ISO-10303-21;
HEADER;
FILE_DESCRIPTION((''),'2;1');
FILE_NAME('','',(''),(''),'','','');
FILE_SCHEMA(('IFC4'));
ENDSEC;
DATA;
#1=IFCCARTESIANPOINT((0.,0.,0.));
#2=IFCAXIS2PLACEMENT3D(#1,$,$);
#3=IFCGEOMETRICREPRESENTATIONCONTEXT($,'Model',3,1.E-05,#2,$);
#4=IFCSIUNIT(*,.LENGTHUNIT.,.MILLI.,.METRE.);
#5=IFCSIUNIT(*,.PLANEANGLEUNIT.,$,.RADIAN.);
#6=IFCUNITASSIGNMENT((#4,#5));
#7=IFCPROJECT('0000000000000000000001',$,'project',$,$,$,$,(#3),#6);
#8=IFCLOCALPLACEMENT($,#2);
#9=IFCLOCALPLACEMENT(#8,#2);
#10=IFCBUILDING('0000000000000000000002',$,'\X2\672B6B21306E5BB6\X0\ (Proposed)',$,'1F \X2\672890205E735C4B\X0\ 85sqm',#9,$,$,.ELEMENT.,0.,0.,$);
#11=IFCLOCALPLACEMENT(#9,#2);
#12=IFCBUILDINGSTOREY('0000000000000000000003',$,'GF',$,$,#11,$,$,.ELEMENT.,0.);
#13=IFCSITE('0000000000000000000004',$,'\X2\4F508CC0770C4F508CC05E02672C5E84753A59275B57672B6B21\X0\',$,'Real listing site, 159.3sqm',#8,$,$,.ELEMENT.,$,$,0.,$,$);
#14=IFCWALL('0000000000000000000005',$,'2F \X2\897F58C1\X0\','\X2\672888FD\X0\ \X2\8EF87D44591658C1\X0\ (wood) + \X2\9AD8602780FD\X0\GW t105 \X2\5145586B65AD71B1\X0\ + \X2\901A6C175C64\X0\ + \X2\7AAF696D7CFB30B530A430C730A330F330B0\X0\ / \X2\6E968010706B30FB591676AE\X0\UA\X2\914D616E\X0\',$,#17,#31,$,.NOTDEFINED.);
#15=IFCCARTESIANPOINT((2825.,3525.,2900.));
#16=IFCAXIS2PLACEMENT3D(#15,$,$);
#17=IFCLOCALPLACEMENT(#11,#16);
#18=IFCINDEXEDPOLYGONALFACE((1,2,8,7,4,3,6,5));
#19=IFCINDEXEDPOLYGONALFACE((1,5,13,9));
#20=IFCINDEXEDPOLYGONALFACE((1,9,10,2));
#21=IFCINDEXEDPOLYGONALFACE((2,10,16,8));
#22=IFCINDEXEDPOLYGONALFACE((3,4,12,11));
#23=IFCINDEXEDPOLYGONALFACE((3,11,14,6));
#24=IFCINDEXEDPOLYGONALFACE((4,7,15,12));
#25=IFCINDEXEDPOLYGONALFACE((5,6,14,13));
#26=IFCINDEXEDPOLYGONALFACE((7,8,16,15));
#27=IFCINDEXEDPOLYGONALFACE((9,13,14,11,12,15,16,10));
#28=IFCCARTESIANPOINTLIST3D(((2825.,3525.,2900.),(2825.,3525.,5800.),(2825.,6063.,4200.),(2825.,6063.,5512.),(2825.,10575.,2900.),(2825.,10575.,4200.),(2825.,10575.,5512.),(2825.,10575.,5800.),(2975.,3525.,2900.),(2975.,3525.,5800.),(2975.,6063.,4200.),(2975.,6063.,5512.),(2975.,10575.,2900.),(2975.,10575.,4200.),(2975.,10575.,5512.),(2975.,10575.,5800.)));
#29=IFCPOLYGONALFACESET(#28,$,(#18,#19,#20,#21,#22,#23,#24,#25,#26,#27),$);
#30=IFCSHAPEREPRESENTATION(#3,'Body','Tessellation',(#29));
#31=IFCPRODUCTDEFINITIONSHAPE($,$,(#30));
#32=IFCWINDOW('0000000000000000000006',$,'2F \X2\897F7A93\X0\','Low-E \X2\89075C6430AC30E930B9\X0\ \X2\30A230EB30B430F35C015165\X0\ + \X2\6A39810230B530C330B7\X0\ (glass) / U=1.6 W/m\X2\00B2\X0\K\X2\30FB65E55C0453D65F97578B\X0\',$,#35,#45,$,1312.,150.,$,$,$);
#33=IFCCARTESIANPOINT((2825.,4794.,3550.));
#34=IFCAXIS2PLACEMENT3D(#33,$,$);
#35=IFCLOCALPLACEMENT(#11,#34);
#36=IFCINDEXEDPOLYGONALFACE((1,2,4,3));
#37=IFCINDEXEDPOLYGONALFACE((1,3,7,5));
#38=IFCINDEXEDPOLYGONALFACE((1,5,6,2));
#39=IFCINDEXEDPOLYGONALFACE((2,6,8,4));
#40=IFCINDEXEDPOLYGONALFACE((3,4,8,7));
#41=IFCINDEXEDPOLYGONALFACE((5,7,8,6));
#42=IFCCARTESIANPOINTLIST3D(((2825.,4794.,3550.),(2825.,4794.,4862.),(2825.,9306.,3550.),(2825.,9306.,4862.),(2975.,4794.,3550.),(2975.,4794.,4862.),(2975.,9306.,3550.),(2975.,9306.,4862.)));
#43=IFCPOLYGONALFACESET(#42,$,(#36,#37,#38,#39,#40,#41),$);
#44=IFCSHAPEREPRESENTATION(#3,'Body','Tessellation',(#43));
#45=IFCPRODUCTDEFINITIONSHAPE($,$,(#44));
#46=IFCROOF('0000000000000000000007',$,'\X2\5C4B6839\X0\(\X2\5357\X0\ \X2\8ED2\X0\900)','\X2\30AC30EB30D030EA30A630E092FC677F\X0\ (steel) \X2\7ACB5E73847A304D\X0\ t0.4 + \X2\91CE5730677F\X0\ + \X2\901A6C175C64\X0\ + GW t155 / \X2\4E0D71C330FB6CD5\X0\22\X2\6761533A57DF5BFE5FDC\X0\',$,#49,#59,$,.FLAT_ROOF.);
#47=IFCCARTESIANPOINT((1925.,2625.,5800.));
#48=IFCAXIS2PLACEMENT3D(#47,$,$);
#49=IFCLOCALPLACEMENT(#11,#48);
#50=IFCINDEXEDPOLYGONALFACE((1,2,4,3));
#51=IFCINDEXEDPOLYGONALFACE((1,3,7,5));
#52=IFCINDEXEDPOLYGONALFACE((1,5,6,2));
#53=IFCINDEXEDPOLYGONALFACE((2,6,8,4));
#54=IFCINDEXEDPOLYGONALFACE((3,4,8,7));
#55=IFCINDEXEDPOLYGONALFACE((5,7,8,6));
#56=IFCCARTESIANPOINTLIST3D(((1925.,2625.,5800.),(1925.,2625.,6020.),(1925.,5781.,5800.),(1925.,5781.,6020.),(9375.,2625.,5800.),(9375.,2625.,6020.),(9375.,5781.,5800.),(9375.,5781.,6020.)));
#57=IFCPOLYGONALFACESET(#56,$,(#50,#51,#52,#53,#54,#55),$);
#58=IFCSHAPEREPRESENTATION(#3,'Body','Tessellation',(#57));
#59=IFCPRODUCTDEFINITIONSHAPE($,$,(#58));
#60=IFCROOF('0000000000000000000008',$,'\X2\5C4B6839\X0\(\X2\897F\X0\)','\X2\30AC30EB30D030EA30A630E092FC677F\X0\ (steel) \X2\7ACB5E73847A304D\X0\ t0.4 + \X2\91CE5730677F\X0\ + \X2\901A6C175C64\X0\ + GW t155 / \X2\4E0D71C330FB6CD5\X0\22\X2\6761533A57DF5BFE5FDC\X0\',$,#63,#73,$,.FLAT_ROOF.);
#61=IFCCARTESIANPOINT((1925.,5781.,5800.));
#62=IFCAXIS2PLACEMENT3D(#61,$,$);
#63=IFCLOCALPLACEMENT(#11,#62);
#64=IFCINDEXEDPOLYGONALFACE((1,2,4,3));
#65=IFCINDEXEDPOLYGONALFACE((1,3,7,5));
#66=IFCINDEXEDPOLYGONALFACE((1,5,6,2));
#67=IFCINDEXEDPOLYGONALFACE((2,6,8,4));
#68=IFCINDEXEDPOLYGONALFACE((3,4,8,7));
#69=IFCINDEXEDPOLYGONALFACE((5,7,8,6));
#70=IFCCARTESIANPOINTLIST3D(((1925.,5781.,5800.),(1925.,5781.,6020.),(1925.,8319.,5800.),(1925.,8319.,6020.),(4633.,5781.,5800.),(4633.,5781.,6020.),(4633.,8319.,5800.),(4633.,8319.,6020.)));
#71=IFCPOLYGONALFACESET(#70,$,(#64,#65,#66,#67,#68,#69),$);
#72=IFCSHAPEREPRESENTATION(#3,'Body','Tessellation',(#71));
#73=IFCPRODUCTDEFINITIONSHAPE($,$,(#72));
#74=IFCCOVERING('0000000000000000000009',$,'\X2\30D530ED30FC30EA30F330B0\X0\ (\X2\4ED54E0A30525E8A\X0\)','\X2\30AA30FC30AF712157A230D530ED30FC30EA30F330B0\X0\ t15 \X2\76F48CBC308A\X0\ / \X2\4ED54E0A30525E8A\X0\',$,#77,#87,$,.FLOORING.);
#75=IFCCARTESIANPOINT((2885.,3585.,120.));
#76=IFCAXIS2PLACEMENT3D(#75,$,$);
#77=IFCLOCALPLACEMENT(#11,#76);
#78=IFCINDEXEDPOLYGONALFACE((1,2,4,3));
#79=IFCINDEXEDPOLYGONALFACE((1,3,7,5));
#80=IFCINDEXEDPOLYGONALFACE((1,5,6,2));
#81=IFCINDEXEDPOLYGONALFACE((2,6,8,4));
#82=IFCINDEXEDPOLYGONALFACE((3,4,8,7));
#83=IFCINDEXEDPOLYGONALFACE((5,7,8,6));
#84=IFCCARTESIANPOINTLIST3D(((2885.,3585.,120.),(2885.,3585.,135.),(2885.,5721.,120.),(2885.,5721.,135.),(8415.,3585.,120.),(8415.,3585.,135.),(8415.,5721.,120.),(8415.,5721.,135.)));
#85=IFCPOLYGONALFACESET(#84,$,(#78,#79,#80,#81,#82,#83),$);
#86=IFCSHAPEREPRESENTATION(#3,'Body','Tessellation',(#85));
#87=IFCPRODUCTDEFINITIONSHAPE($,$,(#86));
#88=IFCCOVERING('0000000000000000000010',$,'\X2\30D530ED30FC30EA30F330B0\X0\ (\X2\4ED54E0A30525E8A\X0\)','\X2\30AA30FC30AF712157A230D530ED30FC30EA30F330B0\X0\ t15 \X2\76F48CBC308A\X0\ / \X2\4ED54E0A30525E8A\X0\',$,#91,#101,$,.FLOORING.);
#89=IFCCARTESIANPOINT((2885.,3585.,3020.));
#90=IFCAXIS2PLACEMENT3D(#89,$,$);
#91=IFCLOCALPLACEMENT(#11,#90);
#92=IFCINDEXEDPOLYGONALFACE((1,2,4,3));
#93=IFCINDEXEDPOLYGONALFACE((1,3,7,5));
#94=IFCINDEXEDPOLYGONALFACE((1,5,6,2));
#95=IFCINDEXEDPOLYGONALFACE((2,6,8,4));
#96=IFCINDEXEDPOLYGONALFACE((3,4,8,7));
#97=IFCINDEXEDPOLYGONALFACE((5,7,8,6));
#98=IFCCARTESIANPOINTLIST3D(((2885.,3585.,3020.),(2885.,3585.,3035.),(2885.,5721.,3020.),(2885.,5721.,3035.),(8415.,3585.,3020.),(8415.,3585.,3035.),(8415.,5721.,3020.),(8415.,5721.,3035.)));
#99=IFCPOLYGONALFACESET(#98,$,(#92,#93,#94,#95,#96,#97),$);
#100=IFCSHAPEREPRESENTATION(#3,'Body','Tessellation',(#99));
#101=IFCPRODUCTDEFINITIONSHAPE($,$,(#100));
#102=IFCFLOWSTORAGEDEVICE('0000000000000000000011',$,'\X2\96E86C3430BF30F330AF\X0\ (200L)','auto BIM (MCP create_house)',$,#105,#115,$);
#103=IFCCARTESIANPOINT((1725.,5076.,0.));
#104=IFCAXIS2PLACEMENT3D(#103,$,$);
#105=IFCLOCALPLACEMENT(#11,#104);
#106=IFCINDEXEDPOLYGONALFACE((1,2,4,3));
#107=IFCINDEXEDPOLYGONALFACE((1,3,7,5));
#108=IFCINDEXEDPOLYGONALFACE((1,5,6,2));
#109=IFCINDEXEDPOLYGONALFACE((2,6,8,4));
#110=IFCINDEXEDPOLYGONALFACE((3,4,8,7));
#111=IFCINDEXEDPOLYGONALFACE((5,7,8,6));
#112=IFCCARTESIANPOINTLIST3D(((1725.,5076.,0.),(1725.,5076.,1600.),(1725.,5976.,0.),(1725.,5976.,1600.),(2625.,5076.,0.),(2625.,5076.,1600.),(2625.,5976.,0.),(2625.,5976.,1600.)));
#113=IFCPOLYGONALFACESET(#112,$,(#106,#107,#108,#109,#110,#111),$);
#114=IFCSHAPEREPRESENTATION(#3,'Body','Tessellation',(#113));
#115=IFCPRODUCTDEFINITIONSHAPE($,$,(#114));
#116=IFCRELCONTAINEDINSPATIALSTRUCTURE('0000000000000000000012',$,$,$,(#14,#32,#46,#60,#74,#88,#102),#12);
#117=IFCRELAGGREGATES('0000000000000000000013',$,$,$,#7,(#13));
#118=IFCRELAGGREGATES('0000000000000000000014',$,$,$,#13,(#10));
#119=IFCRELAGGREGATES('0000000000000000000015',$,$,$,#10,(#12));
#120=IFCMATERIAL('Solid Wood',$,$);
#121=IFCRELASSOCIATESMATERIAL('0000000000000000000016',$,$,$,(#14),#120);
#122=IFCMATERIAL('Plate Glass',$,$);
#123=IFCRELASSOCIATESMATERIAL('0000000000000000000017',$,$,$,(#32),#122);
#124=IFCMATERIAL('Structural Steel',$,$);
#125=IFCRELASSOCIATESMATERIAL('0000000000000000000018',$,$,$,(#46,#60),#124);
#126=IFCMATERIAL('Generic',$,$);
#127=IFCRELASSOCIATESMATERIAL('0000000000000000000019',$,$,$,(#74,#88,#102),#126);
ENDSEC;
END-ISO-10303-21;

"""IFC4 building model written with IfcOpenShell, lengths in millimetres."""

from ifc_helpers import new_model, si_unit, frame, frame_2d, origin, place, context, project, spatial, rectangle, extrude, material, element, fill, save


model = new_model("IFC4")

# Units and contexts
model_context = context("Model", 3, precision=1e-05, world=origin())
ifc_project = project(units=[si_unit("LENGTHUNIT", "METRE", prefix="MILLI"), si_unit("PLANEANGLEUNIT", "RADIAN")], contexts=[model_context])

# Site, building, storey
site_placement = place(None, origin())
site = spatial("IfcSite", under=ifc_project, at=site_placement, Name="佐賀県佐賀市本庄町大字末次", ObjectType="Real listing site, 159.3sqm", CompositionType="ELEMENT", RefElevation=0.0)
building_placement = place(site_placement, origin())
building = spatial("IfcBuilding", under=site, at=building_placement, Name="末次の家 (Proposed)", ObjectType="1F 木造平屋 85sqm", CompositionType="ELEMENT", ElevationOfRefHeight=0.0, ElevationOfTerrain=0.0)
storey_placement = place(building_placement, origin())
storey = spatial("IfcBuildingStorey", under=building, at=storey_placement, Name="GF", CompositionType="ELEMENT", Elevation=0.0)

# Shared definitions
ifc_material_1 = material(Name="Solid Wood")
ifc_material_2 = material(Name="Generic")

# Shared definitions
ifc_material_3 = material(Name="Plate Glass")

# Wall, opening, window
wall_1_placement = place(storey_placement, frame((2825.0, 3525.0, 2900.0)))
wall_1 = element("IfcWall", 1, at=wall_1_placement, inside=storey, material=ifc_material_1, Name="2F 西壁", Description="木製 軸組外壁 (wood) + 高性能GW t105 充填断熱 + 通気層 + 窯業系サイディング / 準耐火・外皮UA配慮", PredefinedType="NOTDEFINED", context=model_context, shape_type="SweptSolid", body=[
    extrude(rectangle(XDim=150.0, YDim=7050.0, at=frame_2d((75.0, 3525.0))), frame((2825.0, 3525.0, 2900.0)), (0.0, 0.0, 1.0), 2900.0),
])
opening_1_placement = place(storey_placement, frame((2825.0, 4794.0, 3550.0)))
opening_1 = element("IfcOpeningElement", 2, at=opening_1_placement, cuts=wall_1, PredefinedType="NOTDEFINED", context=model_context, shape_type="SweptSolid", body=[
    extrude(rectangle(XDim=150.0, YDim=4512.0, at=frame_2d((75.0, 2256.0))), frame((2825.0, 4794.0, 3550.0)), (0.0, 0.0, 1.0), 1312.0),
])
window_1_placement = place(storey_placement, frame((2825.0, 4794.0, 3550.0)))
window_1 = element("IfcWindow", 3, at=window_1_placement, inside=storey, material=ifc_material_3, Name="2F 西窓", Description="Low-E 複層ガラス アルゴン封入 + 樹脂サッシ (glass) / U=1.6 W/m²K・日射取得型", OverallHeight=1312.0, OverallWidth=150.0, context=model_context, shape_type="SweptSolid", body=[
    extrude(rectangle(XDim=150.0, YDim=4512.0, at=frame_2d((75.0, 2256.0))), frame((2825.0, 4794.0, 3550.0)), (0.0, 0.0, 1.0), 1312.0),
])
fill(opening_1, window_1)

# Roofs
ifc_material_4 = material(Name="Structural Steel")
roof_1_placement = place(storey_placement, frame((1925.0, 2625.0, 5800.0)))
element("IfcRoof", 4, at=roof_1_placement, inside=storey, material=ifc_material_4, Name="屋根(南 軒900)", Description="ガルバリウム鋼板 (steel) 立平葺き t0.4 + 野地板 + 通気層 + GW t155 / 不燃・法22条区域対応", PredefinedType="FLAT_ROOF", context=model_context, shape_type="SweptSolid", body=[
    extrude(rectangle(XDim=7450.0, YDim=3156.0, at=frame_2d((3725.0, 1578.0))), frame((1925.0, 2625.0, 5800.0)), (0.0, 0.0, 1.0), 220.0),
])
roof_2_placement = place(storey_placement, frame((1925.0, 5781.0, 5800.0)))
element("IfcRoof", 5, at=roof_2_placement, inside=storey, material=ifc_material_4, Name="屋根(西)", Description="ガルバリウム鋼板 (steel) 立平葺き t0.4 + 野地板 + 通気層 + GW t155 / 不燃・法22条区域対応", PredefinedType="FLAT_ROOF", context=model_context, shape_type="SweptSolid", body=[
    extrude(rectangle(XDim=2708.0, YDim=2538.0, at=frame_2d((1354.0, 1269.0))), frame((1925.0, 5781.0, 5800.0)), (0.0, 0.0, 1.0), 220.0),
])

# Coverings
covering_1_placement = place(storey_placement, frame((2885.0, 3585.0, 120.0)))
element("IfcCovering", 6, at=covering_1_placement, inside=storey, material=ifc_material_2, Name="フローリング (仕上げ床)", Description="オーク無垢フローリング t15 直貼り / 仕上げ床", PredefinedType="FLOORING", context=model_context, shape_type="SweptSolid", body=[
    extrude(rectangle(XDim=5530.0, YDim=2136.0, at=frame_2d((2765.0, 1068.0))), frame((2885.0, 3585.0, 120.0)), (0.0, 0.0, 1.0), 15.0),
])
covering_2_placement = place(storey_placement, frame((2885.0, 3585.0, 3020.0)))
element("IfcCovering", 7, at=covering_2_placement, inside=storey, material=ifc_material_2, Name="フローリング (仕上げ床)", Description="オーク無垢フローリング t15 直貼り / 仕上げ床", PredefinedType="FLOORING", context=model_context, shape_type="SweptSolid", body=[
    extrude(rectangle(XDim=5530.0, YDim=2136.0, at=frame_2d((2765.0, 1068.0))), frame((2885.0, 3585.0, 3020.0)), (0.0, 0.0, 1.0), 15.0),
])

# Flow storage device
flow_storage_device_placement = place(storey_placement, frame((1725.0, 5076.0, 0.0)))
element("IfcFlowStorageDevice", 8, at=flow_storage_device_placement, inside=storey, material=ifc_material_2, Name="雨水タンク (200L)", Description="auto BIM (MCP create_house)", context=model_context, shape_type="SweptSolid", body=[
    extrude(rectangle(XDim=900.0, YDim=900.0, at=frame_2d((450.0, 450.0))), frame((1725.0, 5076.0, 0.0)), (0.0, 0.0, 1.0), 1600.0),
])

save(model, "model.ifc")
